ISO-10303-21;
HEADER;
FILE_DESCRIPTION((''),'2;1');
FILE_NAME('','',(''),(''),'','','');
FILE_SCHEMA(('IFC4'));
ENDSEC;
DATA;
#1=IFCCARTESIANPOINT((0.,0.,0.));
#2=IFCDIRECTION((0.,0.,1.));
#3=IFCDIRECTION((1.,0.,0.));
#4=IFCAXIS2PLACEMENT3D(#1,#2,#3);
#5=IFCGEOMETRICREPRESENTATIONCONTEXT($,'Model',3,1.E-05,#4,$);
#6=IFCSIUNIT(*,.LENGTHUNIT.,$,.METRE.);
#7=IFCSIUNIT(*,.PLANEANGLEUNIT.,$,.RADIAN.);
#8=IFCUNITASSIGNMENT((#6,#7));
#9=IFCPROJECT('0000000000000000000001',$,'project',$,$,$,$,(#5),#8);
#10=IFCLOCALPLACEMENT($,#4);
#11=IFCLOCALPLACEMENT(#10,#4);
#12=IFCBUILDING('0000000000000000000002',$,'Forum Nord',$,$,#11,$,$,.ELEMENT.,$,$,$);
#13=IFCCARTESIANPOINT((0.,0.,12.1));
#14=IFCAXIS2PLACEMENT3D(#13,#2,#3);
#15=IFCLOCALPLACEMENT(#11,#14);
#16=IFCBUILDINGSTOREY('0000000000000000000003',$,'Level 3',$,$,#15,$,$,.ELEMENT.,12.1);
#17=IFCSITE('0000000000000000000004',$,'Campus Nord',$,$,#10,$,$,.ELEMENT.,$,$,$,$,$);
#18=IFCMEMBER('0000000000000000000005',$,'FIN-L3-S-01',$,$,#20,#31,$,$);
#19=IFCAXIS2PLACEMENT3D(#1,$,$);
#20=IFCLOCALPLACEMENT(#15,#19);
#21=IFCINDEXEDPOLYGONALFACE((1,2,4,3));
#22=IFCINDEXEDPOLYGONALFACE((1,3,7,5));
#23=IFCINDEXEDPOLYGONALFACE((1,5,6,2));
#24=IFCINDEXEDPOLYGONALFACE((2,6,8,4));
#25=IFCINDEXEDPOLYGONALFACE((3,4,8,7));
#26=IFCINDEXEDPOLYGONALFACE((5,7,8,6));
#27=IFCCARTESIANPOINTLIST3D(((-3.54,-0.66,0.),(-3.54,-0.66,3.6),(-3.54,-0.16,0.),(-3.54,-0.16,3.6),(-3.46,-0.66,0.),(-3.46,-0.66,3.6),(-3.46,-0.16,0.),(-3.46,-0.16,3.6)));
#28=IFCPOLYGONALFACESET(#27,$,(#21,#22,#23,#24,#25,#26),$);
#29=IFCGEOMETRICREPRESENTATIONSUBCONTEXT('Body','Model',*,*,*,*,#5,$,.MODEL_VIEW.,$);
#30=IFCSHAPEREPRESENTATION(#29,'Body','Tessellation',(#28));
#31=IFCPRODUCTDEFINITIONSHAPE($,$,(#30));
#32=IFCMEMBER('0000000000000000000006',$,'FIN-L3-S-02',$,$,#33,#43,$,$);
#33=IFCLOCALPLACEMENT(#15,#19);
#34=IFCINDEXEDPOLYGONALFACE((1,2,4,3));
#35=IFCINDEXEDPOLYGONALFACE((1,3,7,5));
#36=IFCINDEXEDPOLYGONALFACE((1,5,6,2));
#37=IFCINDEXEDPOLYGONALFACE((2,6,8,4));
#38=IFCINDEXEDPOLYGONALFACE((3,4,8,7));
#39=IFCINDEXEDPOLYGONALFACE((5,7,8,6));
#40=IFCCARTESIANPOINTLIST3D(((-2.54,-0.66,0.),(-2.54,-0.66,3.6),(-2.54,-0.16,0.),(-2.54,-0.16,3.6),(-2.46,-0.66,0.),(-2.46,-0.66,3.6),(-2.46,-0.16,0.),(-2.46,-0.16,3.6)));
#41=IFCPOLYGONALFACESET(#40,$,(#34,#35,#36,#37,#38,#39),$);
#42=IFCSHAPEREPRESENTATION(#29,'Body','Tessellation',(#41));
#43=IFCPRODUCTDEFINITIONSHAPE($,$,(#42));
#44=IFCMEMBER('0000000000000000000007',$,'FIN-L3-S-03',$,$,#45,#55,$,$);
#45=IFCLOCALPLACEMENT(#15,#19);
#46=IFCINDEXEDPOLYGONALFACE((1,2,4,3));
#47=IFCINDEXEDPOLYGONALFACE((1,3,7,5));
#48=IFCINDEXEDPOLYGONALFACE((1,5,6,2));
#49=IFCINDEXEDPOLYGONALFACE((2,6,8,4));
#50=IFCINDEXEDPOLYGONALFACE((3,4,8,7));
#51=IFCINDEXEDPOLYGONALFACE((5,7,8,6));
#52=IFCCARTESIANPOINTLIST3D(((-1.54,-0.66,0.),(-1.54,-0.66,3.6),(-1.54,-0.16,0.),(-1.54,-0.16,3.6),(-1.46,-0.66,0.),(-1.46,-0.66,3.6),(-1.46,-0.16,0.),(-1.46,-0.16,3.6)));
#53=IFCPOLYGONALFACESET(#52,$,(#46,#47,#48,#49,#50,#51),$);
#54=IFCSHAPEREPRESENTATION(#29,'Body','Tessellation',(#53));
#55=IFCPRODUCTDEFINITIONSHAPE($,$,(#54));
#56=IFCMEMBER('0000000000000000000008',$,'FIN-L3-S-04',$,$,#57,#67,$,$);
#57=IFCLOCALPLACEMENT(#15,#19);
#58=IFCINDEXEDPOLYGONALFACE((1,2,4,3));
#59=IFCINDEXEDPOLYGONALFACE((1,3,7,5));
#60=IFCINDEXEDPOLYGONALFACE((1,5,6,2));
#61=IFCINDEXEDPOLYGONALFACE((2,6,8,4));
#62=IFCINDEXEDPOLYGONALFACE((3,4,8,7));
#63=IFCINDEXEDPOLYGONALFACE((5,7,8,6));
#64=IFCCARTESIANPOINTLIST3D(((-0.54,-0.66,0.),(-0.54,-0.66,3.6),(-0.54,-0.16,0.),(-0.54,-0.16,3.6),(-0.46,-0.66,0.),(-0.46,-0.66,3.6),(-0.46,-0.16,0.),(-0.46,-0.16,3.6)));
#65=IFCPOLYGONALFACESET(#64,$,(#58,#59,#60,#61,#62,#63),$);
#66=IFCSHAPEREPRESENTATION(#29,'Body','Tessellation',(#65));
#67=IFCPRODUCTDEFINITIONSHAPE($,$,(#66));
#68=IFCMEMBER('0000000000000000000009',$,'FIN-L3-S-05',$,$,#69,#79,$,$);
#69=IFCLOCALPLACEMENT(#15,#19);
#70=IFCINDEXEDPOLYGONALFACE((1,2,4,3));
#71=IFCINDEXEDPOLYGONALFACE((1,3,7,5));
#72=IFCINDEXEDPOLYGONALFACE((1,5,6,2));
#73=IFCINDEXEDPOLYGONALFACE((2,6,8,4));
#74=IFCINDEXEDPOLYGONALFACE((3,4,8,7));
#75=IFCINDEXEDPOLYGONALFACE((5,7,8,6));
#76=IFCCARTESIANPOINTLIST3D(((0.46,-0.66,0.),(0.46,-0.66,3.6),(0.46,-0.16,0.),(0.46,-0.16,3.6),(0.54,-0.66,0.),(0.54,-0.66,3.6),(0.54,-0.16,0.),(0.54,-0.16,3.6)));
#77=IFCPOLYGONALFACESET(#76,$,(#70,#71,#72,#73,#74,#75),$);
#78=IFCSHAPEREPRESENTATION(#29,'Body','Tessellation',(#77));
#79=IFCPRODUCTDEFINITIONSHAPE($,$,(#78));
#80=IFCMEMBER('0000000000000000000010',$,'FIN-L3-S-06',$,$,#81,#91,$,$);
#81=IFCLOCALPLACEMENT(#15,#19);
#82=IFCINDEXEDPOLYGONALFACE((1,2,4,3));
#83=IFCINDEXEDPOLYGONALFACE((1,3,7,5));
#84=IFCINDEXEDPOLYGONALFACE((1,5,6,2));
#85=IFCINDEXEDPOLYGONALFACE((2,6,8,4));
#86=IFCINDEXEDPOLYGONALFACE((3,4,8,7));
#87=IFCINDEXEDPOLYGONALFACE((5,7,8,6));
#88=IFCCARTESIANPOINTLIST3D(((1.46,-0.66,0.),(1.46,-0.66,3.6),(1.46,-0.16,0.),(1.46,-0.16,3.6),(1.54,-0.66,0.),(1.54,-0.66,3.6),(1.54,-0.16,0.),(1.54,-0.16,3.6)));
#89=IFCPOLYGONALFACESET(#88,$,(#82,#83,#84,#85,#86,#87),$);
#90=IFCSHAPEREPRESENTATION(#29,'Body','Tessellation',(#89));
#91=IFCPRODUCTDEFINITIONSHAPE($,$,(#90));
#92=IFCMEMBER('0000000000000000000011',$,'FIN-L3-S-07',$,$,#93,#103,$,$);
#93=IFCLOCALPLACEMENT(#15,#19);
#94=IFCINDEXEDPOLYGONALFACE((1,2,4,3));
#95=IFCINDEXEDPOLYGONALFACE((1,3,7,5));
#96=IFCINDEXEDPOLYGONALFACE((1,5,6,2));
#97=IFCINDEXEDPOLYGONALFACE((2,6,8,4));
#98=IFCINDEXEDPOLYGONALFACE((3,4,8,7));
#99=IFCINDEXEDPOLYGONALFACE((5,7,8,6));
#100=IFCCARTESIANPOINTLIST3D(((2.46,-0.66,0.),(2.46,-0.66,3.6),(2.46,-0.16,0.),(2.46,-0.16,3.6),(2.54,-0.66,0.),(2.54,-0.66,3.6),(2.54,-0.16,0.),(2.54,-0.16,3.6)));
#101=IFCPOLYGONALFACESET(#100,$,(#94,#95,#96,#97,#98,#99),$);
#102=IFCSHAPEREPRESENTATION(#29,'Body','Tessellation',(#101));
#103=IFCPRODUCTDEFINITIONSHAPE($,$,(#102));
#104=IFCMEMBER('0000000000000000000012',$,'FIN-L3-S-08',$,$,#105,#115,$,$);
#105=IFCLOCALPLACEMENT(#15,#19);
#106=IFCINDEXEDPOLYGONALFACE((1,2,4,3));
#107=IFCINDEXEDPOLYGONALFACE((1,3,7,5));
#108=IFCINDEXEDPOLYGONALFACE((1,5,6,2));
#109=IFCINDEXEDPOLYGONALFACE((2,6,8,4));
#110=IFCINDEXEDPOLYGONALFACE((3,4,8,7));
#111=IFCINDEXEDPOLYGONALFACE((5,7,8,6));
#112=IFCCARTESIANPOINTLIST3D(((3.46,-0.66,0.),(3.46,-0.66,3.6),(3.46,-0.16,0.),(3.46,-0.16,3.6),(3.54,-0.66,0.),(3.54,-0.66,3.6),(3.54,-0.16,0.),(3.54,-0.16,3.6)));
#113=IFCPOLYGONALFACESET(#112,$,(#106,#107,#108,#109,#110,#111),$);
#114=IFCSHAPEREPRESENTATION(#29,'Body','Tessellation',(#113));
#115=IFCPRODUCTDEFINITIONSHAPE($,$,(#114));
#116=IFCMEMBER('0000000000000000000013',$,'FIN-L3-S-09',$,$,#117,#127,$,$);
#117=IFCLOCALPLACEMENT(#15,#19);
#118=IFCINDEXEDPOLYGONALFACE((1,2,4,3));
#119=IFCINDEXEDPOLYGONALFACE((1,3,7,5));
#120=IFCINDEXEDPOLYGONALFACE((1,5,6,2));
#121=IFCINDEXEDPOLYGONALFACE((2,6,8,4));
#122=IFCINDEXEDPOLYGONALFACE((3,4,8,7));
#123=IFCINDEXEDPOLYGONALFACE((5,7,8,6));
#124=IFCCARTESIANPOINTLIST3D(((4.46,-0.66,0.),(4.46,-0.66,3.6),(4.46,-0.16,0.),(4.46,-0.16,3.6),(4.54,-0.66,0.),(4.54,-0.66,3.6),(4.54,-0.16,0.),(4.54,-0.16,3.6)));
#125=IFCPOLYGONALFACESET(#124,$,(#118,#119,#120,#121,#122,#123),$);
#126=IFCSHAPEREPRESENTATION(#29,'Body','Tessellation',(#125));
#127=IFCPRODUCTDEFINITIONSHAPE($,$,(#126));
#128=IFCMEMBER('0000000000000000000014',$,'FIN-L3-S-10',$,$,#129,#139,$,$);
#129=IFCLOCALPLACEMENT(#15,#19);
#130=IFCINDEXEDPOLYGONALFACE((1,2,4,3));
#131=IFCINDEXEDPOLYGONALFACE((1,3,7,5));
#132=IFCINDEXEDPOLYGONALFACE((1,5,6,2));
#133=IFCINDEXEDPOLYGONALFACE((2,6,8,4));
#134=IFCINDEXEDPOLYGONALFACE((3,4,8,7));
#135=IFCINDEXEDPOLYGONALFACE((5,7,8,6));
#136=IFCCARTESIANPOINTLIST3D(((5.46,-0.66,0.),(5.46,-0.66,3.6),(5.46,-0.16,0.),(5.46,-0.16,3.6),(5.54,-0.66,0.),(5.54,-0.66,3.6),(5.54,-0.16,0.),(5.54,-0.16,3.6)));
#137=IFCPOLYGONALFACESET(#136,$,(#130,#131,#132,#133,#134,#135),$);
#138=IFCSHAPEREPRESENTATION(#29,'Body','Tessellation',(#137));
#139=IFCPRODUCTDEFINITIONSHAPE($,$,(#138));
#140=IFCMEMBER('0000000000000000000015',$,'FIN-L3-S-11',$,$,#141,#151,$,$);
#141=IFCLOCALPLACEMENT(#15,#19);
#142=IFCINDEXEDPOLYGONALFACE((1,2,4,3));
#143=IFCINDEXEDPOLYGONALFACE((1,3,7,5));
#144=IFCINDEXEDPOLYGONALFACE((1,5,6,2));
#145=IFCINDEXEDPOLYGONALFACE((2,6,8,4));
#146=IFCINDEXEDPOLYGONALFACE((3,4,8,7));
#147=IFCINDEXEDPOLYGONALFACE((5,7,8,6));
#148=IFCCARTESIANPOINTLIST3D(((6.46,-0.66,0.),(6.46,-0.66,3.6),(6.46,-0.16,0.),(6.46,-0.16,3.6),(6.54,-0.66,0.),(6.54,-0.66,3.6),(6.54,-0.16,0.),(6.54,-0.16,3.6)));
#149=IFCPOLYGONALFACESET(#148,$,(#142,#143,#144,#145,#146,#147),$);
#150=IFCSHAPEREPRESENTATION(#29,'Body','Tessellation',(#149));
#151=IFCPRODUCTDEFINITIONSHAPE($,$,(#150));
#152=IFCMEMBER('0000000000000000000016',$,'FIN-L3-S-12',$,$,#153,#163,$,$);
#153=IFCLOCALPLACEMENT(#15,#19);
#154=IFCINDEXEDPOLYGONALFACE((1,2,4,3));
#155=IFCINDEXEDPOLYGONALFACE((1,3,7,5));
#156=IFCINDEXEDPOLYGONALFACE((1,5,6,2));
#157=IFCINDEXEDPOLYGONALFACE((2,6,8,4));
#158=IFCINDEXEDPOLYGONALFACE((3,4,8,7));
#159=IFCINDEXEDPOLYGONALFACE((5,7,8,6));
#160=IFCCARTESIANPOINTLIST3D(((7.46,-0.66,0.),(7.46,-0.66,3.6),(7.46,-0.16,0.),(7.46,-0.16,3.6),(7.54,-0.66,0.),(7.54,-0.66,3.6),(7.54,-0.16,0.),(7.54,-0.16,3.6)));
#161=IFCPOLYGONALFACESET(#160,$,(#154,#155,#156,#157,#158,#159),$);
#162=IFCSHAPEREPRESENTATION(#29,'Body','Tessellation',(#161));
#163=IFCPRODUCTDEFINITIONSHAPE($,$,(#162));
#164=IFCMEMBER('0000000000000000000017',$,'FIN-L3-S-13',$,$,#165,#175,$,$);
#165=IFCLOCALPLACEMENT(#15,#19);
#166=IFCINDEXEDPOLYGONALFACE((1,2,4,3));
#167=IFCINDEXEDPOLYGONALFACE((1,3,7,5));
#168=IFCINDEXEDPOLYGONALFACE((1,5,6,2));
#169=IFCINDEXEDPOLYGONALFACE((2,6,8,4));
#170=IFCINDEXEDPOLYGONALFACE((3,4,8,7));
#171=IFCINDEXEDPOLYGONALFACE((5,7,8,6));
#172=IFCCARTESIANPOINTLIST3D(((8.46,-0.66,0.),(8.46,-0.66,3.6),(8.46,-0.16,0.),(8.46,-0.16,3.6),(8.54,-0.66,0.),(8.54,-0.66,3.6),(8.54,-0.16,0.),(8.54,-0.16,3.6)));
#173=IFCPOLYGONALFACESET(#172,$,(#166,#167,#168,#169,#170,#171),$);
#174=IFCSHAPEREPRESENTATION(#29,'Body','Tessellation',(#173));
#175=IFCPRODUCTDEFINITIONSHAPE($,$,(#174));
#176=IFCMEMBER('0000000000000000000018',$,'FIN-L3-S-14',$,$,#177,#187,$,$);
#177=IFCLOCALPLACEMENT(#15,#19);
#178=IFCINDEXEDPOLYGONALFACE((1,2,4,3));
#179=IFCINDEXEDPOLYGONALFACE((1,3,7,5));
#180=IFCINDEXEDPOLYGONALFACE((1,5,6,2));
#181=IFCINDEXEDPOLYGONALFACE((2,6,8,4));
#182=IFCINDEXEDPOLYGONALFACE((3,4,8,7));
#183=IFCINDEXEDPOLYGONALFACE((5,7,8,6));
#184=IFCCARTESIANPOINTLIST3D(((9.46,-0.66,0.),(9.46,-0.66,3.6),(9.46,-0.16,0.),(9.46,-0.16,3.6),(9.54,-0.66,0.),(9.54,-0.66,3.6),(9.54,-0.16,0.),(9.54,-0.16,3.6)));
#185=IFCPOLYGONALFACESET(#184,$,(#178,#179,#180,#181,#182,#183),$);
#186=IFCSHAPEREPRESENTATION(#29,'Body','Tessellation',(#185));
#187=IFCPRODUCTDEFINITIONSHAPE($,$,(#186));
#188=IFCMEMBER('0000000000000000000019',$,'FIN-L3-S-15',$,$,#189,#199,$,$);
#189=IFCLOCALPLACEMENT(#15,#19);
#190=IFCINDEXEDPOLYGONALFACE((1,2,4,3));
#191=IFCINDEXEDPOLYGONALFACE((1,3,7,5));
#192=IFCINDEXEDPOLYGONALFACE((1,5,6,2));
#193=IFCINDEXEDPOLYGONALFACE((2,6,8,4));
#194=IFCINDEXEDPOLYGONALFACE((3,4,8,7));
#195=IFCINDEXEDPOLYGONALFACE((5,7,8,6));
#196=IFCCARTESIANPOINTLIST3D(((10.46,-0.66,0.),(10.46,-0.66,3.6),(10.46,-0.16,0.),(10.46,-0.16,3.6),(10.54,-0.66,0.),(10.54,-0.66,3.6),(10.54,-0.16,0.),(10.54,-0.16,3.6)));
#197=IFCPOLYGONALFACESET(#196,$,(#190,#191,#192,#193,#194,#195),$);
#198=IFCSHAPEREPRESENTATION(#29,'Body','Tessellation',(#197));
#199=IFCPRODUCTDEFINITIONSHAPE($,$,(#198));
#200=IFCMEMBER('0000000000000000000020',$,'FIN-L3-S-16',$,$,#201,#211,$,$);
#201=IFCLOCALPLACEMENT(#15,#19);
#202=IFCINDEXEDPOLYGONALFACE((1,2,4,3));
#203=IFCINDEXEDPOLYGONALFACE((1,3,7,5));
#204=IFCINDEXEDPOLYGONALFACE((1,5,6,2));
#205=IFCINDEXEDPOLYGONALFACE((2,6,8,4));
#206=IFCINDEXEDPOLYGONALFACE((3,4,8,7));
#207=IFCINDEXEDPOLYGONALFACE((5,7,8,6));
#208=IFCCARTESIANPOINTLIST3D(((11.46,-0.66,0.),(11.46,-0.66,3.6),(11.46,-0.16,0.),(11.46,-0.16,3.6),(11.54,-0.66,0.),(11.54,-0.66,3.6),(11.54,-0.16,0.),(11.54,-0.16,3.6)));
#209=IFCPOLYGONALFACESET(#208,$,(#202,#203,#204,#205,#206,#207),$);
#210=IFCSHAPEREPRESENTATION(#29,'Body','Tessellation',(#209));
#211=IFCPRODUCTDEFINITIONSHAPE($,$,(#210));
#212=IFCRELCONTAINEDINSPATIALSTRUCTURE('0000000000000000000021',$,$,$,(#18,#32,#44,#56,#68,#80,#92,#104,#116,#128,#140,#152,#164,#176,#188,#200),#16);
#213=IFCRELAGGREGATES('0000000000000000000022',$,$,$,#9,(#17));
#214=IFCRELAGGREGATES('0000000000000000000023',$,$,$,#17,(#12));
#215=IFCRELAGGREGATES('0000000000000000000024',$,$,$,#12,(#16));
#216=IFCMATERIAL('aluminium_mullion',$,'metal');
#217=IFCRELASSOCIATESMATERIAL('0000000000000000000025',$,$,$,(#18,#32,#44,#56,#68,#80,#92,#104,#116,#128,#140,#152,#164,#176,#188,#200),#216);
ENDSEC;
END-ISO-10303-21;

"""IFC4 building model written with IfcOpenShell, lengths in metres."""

from ifc_helpers import new_model, si_unit, frame, origin_with_axes, place, context, subcontext, project, spatial, polyline, outline, extrude, material, element, save


model = new_model("IFC4")

# Units and contexts
model_context = context("Model", 3, precision=1e-05, world=origin_with_axes())
body_context = subcontext(model_context, "Body", "Model", "MODEL_VIEW")
ifc_project = project(units=[si_unit("LENGTHUNIT", "METRE"), si_unit("PLANEANGLEUNIT", "RADIAN")], contexts=[model_context])

# Site, building, storey
site_placement = place(None, origin_with_axes())
site = spatial("IfcSite", under=ifc_project, at=site_placement, Name="Campus Nord", CompositionType="ELEMENT")
building_placement = place(site_placement, origin_with_axes())
building = spatial("IfcBuilding", under=site, at=building_placement, Name="Forum Nord", CompositionType="ELEMENT")
storey_placement = place(building_placement, frame((0.0, 0.0, 12.1), z_axis=(0.0, 0.0, 1.0), x_axis=(1.0, 0.0, 0.0)))
storey = spatial("IfcBuildingStorey", under=building, at=storey_placement, Name="Level 3", CompositionType="ELEMENT", Elevation=12.1)

# Members
ifc_material_1 = material(Name="aluminium_mullion", Category="metal")
member_1_placement = place(storey_placement, origin_with_axes())
element("IfcMember", 1, at=member_1_placement, inside=storey, material=ifc_material_1, Name="FIN-L3-S-01", context=body_context, shape_type="SweptSolid", body=[
    extrude(outline(polyline([(-3.54, -0.66), (-3.46, -0.66), (-3.46, -0.16), (-3.54, -0.16), (-3.54, -0.66)])), origin_with_axes(), (0.0, 0.0, 1.0), 3.6),
])
member_2_placement = place(storey_placement, origin_with_axes())
element("IfcMember", 2, at=member_2_placement, inside=storey, material=ifc_material_1, Name="FIN-L3-S-02", context=body_context, shape_type="SweptSolid", body=[
    extrude(outline(polyline([(-2.54, -0.66), (-2.46, -0.66), (-2.46, -0.16), (-2.54, -0.16), (-2.54, -0.66)])), origin_with_axes(), (0.0, 0.0, 1.0), 3.6),
])
member_3_placement = place(storey_placement, origin_with_axes())
element("IfcMember", 3, at=member_3_placement, inside=storey, material=ifc_material_1, Name="FIN-L3-S-03", context=body_context, shape_type="SweptSolid", body=[
    extrude(outline(polyline([(-1.54, -0.66), (-1.46, -0.66), (-1.46, -0.16), (-1.54, -0.16), (-1.54, -0.66)])), origin_with_axes(), (0.0, 0.0, 1.0), 3.6),
])
member_4_placement = place(storey_placement, origin_with_axes())
element("IfcMember", 4, at=member_4_placement, inside=storey, material=ifc_material_1, Name="FIN-L3-S-04", context=body_context, shape_type="SweptSolid", body=[
    extrude(outline(polyline([(-0.54, -0.66), (-0.46, -0.66), (-0.46, -0.16), (-0.54, -0.16), (-0.54, -0.66)])), origin_with_axes(), (0.0, 0.0, 1.0), 3.6),
])
member_5_placement = place(storey_placement, origin_with_axes())
element("IfcMember", 5, at=member_5_placement, inside=storey, material=ifc_material_1, Name="FIN-L3-S-05", context=body_context, shape_type="SweptSolid", body=[
    extrude(outline(polyline([(0.46, -0.66), (0.54, -0.66), (0.54, -0.16), (0.46, -0.16), (0.46, -0.66)])), origin_with_axes(), (0.0, 0.0, 1.0), 3.6),
])
member_6_placement = place(storey_placement, origin_with_axes())
element("IfcMember", 6, at=member_6_placement, inside=storey, material=ifc_material_1, Name="FIN-L3-S-06", context=body_context, shape_type="SweptSolid", body=[
    extrude(outline(polyline([(1.46, -0.66), (1.54, -0.66), (1.54, -0.16), (1.46, -0.16), (1.46, -0.66)])), origin_with_axes(), (0.0, 0.0, 1.0), 3.6),
])
member_7_placement = place(storey_placement, origin_with_axes())
element("IfcMember", 7, at=member_7_placement, inside=storey, material=ifc_material_1, Name="FIN-L3-S-07", context=body_context, shape_type="SweptSolid", body=[
    extrude(outline(polyline([(2.46, -0.66), (2.54, -0.66), (2.54, -0.16), (2.46, -0.16), (2.46, -0.66)])), origin_with_axes(), (0.0, 0.0, 1.0), 3.6),
])
member_8_placement = place(storey_placement, origin_with_axes())
element("IfcMember", 8, at=member_8_placement, inside=storey, material=ifc_material_1, Name="FIN-L3-S-08", context=body_context, shape_type="SweptSolid", body=[
    extrude(outline(polyline([(3.46, -0.66), (3.54, -0.66), (3.54, -0.16), (3.46, -0.16), (3.46, -0.66)])), origin_with_axes(), (0.0, 0.0, 1.0), 3.6),
])
member_9_placement = place(storey_placement, origin_with_axes())
element("IfcMember", 9, at=member_9_placement, inside=storey, material=ifc_material_1, Name="FIN-L3-S-09", context=body_context, shape_type="SweptSolid", body=[
    extrude(outline(polyline([(4.46, -0.66), (4.54, -0.66), (4.54, -0.16), (4.46, -0.16), (4.46, -0.66)])), origin_with_axes(), (0.0, 0.0, 1.0), 3.6),
])
member_10_placement = place(storey_placement, origin_with_axes())
element("IfcMember", 10, at=member_10_placement, inside=storey, material=ifc_material_1, Name="FIN-L3-S-10", context=body_context, shape_type="SweptSolid", body=[
    extrude(outline(polyline([(5.46, -0.66), (5.54, -0.66), (5.54, -0.16), (5.46, -0.16), (5.46, -0.66)])), origin_with_axes(), (0.0, 0.0, 1.0), 3.6),
])
member_11_placement = place(storey_placement, origin_with_axes())
element("IfcMember", 11, at=member_11_placement, inside=storey, material=ifc_material_1, Name="FIN-L3-S-11", context=body_context, shape_type="SweptSolid", body=[
    extrude(outline(polyline([(6.46, -0.66), (6.54, -0.66), (6.54, -0.16), (6.46, -0.16), (6.46, -0.66)])), origin_with_axes(), (0.0, 0.0, 1.0), 3.6),
])
member_12_placement = place(storey_placement, origin_with_axes())
element("IfcMember", 12, at=member_12_placement, inside=storey, material=ifc_material_1, Name="FIN-L3-S-12", context=body_context, shape_type="SweptSolid", body=[
    extrude(outline(polyline([(7.46, -0.66), (7.54, -0.66), (7.54, -0.16), (7.46, -0.16), (7.46, -0.66)])), origin_with_axes(), (0.0, 0.0, 1.0), 3.6),
])
member_13_placement = place(storey_placement, origin_with_axes())
element("IfcMember", 13, at=member_13_placement, inside=storey, material=ifc_material_1, Name="FIN-L3-S-13", context=body_context, shape_type="SweptSolid", body=[
    extrude(outline(polyline([(8.46, -0.66), (8.54, -0.66), (8.54, -0.16), (8.46, -0.16), (8.46, -0.66)])), origin_with_axes(), (0.0, 0.0, 1.0), 3.6),
])
member_14_placement = place(storey_placement, origin_with_axes())
element("IfcMember", 14, at=member_14_placement, inside=storey, material=ifc_material_1, Name="FIN-L3-S-14", context=body_context, shape_type="SweptSolid", body=[
    extrude(outline(polyline([(9.46, -0.66), (9.54, -0.66), (9.54, -0.16), (9.46, -0.16), (9.46, -0.66)])), origin_with_axes(), (0.0, 0.0, 1.0), 3.6),
])
member_15_placement = place(storey_placement, origin_with_axes())
element("IfcMember", 15, at=member_15_placement, inside=storey, material=ifc_material_1, Name="FIN-L3-S-15", context=body_context, shape_type="SweptSolid", body=[
    extrude(outline(polyline([(10.46, -0.66), (10.54, -0.66), (10.54, -0.16), (10.46, -0.16), (10.46, -0.66)])), origin_with_axes(), (0.0, 0.0, 1.0), 3.6),
])
member_16_placement = place(storey_placement, origin_with_axes())
element("IfcMember", 16, at=member_16_placement, inside=storey, material=ifc_material_1, Name="FIN-L3-S-16", context=body_context, shape_type="SweptSolid", body=[
    extrude(outline(polyline([(11.46, -0.66), (11.54, -0.66), (11.54, -0.16), (11.46, -0.16), (11.46, -0.66)])), origin_with_axes(), (0.0, 0.0, 1.0), 3.6),
])

save(model, "model.ifc")
